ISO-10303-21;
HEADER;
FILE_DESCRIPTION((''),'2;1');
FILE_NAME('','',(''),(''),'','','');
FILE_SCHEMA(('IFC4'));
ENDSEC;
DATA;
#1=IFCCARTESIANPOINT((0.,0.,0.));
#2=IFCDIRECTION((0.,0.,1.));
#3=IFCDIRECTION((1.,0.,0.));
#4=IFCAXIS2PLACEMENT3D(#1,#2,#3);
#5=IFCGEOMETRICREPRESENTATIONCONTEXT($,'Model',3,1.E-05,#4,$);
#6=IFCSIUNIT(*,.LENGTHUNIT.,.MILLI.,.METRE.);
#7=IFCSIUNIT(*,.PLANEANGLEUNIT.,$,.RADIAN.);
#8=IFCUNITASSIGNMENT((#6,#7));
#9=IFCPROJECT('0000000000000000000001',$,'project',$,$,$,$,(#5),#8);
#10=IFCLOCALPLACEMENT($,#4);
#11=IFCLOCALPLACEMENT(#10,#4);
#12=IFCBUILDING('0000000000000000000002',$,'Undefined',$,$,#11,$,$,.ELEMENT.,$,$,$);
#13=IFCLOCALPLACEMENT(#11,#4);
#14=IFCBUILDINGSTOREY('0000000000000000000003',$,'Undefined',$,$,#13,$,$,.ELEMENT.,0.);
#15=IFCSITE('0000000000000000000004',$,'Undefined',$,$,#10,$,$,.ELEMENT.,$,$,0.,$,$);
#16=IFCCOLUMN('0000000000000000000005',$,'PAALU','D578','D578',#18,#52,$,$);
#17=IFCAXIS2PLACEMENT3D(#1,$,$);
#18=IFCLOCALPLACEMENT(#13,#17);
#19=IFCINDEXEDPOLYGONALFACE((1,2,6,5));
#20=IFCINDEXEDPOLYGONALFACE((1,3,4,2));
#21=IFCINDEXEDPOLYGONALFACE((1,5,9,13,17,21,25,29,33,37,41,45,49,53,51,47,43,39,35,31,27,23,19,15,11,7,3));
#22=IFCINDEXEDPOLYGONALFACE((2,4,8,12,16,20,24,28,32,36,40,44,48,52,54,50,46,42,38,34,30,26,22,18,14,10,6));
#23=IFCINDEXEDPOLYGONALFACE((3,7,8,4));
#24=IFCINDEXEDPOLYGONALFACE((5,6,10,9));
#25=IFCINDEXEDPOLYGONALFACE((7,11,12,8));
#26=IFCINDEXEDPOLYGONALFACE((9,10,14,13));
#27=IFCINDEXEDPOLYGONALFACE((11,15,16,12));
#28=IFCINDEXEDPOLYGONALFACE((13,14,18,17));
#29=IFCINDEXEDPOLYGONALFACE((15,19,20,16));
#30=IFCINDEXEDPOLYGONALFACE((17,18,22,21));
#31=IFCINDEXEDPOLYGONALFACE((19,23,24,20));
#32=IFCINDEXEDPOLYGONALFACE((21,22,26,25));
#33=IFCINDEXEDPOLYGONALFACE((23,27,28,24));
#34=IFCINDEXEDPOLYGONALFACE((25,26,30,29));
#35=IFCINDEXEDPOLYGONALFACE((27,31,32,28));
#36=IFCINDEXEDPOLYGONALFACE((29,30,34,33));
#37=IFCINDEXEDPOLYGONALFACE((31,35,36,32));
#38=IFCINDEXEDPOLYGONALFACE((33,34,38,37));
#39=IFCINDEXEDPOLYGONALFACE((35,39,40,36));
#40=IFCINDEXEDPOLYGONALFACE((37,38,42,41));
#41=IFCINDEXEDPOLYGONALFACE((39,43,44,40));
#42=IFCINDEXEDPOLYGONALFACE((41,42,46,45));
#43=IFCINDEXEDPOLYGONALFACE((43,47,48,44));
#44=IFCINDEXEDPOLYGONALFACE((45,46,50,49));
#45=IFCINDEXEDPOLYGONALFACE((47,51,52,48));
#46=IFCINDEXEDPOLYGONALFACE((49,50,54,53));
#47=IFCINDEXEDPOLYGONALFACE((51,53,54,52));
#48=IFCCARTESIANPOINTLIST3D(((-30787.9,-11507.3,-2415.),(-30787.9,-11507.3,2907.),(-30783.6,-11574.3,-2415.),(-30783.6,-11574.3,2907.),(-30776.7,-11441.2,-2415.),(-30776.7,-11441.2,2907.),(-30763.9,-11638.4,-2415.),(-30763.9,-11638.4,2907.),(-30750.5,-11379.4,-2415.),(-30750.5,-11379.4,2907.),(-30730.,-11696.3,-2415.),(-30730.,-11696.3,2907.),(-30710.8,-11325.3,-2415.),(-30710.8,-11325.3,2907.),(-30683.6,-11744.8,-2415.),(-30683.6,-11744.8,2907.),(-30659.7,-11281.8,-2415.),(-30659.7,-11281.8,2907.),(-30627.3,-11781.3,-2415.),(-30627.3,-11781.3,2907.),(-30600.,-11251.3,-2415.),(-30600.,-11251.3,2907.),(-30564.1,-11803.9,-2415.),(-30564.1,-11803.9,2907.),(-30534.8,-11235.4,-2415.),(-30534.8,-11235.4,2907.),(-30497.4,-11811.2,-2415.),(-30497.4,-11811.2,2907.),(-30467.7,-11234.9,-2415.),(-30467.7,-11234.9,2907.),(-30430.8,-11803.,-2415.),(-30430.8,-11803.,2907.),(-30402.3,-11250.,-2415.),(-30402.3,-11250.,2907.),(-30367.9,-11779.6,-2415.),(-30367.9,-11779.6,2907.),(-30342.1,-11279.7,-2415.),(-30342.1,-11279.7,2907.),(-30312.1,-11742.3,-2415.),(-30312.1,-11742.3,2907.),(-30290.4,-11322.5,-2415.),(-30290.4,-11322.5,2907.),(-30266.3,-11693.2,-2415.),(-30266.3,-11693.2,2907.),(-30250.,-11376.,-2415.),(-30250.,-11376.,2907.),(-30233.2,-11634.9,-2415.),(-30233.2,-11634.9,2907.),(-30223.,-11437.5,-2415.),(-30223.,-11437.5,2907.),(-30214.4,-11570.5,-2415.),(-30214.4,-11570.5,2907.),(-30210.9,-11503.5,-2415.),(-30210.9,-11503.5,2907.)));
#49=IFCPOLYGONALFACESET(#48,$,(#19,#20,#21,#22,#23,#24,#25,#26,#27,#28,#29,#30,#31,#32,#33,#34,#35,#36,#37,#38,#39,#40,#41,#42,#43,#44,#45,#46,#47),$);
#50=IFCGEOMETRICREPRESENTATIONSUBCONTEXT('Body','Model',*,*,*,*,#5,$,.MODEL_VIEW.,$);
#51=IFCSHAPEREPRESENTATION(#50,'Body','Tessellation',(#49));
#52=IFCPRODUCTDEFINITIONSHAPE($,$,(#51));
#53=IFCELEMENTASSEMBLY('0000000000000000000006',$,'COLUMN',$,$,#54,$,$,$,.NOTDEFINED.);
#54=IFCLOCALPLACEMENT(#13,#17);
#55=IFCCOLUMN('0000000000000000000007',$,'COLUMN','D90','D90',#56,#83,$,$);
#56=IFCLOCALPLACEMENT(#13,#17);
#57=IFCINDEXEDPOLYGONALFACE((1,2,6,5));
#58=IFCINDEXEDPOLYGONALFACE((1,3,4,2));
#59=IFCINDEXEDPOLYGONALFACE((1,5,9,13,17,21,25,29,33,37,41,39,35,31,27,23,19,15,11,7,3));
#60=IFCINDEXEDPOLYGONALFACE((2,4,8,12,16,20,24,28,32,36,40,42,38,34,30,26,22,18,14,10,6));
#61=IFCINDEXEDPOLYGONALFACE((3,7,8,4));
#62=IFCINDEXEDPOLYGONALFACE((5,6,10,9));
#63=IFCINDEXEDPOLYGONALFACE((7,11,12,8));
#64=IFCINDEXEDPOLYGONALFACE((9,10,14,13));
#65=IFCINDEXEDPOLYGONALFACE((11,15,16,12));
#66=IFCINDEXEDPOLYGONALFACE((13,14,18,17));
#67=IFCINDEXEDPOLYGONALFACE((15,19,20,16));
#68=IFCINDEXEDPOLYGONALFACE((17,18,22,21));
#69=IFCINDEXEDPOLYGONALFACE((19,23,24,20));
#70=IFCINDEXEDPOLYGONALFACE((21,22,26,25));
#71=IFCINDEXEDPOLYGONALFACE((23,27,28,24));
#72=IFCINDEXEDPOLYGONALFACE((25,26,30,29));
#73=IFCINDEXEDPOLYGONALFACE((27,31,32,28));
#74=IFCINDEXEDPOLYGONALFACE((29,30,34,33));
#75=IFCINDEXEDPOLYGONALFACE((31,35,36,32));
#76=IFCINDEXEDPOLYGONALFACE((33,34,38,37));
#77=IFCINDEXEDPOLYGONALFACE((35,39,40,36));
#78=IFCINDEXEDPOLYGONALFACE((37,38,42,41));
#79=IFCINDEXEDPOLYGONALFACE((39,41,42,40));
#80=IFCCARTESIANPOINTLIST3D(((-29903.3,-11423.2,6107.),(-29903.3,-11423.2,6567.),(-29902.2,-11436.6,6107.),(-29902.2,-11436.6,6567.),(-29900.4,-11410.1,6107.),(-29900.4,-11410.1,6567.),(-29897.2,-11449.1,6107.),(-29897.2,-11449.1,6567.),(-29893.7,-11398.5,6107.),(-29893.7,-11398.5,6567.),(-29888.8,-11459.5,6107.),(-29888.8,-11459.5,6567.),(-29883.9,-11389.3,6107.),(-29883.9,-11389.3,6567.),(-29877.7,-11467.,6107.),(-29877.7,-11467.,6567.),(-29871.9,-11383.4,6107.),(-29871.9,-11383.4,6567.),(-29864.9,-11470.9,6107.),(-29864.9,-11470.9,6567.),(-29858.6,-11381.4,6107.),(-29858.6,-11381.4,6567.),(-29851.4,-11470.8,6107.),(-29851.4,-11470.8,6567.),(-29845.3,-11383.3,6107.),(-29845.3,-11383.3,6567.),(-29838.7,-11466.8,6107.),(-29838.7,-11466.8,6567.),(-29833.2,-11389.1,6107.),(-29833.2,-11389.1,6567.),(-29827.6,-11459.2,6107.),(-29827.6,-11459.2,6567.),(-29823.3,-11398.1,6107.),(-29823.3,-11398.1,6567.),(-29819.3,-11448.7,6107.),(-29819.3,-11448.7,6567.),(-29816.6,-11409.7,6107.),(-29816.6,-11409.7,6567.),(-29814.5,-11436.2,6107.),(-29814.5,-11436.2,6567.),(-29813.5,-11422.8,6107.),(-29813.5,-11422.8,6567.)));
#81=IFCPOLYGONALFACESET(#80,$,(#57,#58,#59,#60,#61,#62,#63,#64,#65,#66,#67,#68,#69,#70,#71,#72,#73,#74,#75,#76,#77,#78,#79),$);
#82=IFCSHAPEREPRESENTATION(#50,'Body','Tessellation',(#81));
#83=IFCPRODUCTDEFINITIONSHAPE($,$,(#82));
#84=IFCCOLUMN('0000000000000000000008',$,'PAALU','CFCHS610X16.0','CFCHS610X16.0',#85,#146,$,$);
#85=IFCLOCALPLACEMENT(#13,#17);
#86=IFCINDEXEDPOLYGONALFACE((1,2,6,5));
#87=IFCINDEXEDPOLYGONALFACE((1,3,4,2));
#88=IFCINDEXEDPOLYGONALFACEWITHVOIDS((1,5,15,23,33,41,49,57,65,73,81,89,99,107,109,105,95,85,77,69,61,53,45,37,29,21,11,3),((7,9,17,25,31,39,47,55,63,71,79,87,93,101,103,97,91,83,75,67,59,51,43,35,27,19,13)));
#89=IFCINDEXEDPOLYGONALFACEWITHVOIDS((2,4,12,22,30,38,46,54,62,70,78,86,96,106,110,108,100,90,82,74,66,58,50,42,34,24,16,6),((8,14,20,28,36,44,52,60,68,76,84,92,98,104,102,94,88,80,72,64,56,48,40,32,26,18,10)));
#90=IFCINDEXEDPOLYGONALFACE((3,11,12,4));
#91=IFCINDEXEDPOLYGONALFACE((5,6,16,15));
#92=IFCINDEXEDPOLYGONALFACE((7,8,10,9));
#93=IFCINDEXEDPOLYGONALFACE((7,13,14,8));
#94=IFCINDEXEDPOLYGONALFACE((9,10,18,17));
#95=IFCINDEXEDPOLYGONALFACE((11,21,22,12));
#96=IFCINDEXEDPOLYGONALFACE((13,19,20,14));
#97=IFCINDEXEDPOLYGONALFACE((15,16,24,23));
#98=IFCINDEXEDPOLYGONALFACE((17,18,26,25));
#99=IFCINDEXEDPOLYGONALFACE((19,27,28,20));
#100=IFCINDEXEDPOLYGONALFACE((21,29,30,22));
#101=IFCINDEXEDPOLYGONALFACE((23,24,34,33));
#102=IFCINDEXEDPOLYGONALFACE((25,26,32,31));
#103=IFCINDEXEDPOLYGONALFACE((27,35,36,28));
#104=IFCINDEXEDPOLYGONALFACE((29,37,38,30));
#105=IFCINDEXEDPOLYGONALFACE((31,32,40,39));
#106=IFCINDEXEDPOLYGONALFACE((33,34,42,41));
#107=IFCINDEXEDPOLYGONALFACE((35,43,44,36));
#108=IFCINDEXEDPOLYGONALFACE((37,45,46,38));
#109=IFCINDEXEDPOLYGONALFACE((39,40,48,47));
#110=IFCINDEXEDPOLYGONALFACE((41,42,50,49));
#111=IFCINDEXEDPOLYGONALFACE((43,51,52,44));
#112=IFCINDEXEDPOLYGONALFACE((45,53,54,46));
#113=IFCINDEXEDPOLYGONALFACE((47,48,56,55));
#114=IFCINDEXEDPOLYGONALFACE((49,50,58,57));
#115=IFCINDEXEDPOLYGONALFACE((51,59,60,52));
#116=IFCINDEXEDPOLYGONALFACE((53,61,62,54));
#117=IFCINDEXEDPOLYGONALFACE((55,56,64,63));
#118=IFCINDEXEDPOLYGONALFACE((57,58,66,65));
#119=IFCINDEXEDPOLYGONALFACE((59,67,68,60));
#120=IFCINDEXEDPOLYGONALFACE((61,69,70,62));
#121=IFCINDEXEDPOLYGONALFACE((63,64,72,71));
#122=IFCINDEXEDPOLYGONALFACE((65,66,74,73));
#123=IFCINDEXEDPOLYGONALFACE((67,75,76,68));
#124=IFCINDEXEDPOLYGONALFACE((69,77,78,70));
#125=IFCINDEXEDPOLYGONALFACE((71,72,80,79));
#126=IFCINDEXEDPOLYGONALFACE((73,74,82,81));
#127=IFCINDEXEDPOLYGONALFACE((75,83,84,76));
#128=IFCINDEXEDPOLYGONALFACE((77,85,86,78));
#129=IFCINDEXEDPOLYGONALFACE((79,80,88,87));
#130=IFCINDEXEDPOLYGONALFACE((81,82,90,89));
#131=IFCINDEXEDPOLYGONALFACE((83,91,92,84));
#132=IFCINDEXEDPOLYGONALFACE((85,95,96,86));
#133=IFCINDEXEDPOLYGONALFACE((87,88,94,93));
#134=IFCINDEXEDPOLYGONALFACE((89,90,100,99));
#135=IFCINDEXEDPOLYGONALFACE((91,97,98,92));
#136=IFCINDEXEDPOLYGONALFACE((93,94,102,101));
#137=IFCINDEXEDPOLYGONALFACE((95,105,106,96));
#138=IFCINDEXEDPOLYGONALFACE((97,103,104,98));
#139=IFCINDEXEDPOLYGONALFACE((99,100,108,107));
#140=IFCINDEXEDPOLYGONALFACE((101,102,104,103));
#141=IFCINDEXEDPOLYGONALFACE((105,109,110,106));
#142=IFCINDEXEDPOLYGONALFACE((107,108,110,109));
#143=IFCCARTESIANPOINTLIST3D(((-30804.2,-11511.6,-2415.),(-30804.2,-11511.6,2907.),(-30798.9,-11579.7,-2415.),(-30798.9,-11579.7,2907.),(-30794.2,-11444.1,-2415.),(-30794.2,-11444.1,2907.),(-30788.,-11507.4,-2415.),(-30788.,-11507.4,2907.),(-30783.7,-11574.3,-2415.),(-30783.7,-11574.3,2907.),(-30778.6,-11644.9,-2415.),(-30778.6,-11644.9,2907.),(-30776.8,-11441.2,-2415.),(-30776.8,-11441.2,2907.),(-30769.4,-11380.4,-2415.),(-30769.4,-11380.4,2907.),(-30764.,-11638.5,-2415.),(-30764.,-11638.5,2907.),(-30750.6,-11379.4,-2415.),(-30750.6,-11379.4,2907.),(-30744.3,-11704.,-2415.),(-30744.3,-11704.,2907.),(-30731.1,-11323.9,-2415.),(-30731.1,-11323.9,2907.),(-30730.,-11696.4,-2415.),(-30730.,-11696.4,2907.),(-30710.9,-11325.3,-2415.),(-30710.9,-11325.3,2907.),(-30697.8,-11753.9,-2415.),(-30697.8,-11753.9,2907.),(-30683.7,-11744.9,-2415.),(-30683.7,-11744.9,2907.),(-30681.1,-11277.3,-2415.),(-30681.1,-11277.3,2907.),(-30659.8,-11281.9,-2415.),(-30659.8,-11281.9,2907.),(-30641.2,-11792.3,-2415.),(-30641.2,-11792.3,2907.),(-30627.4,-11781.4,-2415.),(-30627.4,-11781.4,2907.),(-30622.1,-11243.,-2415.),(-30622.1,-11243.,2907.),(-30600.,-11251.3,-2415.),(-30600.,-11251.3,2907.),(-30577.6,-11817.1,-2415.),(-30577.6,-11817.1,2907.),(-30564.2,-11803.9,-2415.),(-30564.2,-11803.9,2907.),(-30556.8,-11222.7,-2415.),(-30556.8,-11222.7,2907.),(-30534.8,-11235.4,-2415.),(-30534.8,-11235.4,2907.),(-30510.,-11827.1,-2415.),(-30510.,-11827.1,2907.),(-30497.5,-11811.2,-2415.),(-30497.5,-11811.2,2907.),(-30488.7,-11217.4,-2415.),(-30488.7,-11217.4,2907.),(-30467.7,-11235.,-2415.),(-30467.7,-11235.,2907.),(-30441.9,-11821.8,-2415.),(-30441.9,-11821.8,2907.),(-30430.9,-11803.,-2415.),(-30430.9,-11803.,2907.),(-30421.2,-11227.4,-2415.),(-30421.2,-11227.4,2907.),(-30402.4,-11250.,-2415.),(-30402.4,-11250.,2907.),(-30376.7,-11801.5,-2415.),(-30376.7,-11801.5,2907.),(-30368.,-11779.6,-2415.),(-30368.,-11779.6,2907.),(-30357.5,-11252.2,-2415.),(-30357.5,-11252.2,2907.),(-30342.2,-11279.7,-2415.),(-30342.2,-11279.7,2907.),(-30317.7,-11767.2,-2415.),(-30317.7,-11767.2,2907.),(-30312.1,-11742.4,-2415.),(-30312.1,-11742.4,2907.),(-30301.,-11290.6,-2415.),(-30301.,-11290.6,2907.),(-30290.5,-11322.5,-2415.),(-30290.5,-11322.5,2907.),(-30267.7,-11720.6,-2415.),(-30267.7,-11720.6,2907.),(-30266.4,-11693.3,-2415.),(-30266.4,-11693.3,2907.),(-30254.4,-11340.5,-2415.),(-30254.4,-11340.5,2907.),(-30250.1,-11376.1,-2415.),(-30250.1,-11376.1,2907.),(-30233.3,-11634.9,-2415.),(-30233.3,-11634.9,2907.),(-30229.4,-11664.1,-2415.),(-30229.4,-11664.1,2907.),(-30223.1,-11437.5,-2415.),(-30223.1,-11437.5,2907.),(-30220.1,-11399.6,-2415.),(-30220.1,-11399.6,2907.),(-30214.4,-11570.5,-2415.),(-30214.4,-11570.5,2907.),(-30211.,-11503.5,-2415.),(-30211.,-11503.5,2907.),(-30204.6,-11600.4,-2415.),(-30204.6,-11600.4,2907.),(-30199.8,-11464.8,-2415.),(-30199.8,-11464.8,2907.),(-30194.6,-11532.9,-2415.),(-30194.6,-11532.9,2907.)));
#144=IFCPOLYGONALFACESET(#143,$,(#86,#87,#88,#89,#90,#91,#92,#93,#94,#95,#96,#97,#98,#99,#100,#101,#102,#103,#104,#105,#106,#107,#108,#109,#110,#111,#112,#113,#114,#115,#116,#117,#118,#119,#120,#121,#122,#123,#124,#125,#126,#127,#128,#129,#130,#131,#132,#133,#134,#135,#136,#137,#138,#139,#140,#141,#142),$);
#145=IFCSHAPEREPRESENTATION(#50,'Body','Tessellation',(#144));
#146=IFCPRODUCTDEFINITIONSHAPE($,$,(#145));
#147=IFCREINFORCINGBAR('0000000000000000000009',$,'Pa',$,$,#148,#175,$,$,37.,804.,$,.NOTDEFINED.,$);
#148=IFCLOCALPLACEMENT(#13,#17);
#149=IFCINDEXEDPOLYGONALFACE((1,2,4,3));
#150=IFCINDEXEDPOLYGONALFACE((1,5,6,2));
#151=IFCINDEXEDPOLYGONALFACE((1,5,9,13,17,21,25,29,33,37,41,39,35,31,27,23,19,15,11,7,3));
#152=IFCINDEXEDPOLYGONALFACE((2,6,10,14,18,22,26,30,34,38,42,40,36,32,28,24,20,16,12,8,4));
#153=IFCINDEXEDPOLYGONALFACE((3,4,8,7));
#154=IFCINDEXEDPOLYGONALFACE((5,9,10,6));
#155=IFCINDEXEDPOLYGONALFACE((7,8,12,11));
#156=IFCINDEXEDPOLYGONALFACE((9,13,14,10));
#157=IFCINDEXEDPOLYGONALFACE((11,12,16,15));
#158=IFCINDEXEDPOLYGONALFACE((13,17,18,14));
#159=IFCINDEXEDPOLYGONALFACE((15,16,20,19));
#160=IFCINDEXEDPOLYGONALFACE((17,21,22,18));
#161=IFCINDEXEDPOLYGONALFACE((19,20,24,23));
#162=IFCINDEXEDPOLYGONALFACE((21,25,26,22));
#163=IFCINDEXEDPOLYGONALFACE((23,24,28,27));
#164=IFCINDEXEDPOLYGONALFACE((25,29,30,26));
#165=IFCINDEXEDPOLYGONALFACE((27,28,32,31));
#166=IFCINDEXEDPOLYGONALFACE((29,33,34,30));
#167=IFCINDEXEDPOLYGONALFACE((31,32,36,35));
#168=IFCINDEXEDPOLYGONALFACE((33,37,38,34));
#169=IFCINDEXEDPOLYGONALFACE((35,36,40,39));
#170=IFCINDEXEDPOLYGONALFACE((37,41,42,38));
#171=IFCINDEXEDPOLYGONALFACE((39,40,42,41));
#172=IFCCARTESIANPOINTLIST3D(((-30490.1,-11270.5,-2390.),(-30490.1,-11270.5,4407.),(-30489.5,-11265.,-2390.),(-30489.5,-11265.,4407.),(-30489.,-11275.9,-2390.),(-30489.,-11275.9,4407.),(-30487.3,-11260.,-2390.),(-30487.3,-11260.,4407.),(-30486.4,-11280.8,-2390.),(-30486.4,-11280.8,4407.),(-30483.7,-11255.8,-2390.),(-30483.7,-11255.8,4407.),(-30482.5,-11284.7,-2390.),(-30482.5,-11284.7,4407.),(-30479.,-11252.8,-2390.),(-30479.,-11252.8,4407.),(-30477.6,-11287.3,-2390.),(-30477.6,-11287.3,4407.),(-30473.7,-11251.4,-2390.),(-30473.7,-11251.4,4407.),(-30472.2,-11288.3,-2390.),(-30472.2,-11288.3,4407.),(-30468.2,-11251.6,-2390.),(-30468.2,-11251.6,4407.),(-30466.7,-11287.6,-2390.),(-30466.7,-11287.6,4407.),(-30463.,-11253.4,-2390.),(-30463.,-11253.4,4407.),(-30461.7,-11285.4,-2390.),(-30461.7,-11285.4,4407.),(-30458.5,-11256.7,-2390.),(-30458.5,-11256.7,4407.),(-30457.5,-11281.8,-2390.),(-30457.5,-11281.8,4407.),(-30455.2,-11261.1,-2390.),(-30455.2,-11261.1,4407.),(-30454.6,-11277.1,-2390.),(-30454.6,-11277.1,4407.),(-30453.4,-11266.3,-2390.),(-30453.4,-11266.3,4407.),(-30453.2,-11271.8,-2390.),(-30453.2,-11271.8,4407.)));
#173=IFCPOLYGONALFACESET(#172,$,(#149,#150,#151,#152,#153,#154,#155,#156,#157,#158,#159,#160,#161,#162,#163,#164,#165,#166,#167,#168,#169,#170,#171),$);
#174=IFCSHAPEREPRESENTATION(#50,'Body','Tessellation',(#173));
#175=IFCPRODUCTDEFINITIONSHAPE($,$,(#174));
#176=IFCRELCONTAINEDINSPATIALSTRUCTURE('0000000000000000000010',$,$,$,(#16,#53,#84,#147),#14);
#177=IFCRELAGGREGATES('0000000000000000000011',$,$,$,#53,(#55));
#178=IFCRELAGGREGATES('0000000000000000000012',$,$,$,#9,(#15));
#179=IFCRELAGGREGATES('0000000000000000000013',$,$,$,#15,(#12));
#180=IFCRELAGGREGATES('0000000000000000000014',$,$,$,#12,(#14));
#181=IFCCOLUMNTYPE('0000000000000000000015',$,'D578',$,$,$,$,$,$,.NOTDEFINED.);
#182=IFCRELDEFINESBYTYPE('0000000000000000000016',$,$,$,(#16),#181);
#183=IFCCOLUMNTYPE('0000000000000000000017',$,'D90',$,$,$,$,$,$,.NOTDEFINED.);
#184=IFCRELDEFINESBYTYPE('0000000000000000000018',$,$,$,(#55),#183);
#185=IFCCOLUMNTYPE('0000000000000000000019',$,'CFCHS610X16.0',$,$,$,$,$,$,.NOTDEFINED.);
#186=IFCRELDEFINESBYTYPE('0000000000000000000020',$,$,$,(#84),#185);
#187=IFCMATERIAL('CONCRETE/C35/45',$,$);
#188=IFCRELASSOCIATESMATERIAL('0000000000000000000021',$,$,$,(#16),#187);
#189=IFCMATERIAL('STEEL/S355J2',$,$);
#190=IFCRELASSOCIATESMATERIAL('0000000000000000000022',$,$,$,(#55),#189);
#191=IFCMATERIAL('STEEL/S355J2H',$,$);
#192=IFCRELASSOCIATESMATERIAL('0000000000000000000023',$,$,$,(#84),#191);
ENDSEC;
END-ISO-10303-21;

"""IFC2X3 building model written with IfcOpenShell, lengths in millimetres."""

from ifc_helpers import new_model, entity, si_unit, frame, origin_with_axes, origin_2d_with_axis, place, context, subcontext, project, spatial, circle, hollow_circle, extrude, source, transform, mapped, material, type_object, element, aggregate, save


model = new_model("IFC2X3")

# Units and contexts
model_context = context("Model", 3, precision=1e-05, world=origin_with_axes())
body_context = subcontext(model_context, "Body", "Model", "MODEL_VIEW")
ifc_project = project(units=[si_unit("LENGTHUNIT", "METRE", prefix="MILLI"), si_unit("PLANEANGLEUNIT", "RADIAN")], contexts=[model_context])

# Site, building, storey
site_placement = place(None, origin_with_axes())
site = spatial("IfcSite", under=ifc_project, at=site_placement, Name="Undefined", CompositionType="ELEMENT", RefElevation=0.0)
building_placement = place(site_placement, origin_with_axes())
building = spatial("IfcBuilding", under=site, at=building_placement, Name="Undefined", CompositionType="ELEMENT")
storey_placement = place(building_placement, origin_with_axes())
storey = spatial("IfcBuildingStorey", under=building, at=storey_placement, Name="Undefined", CompositionType="ELEMENT", Elevation=0.0)

# Column
ifc_material_1 = material(Name="CONCRETE/C35/45")
column_type_1 = type_object("IfcColumnType", Name="D578", PredefinedType="NOTDEFINED")
column_1_placement = place(storey_placement, frame((-30499.3, -11522.2, -2415.0), z_axis=(0.0, 0.0, 1.0), x_axis=(1.0, 0.0, 0.0)))
element("IfcColumn", 1, at=column_1_placement, inside=storey, type_object=column_type_1, material=ifc_material_1, Name="PAALU", Description="D578", ObjectType="D578", context=body_context, shape_type="SweptSolid", body=[
    extrude(circle(Radius=289.0, at=origin_2d_with_axis()), frame((0.0, 0.0, 5322.0), z_axis=(0.0, 0.0, -1.0), x_axis=(-0.915553, -0.402197, 0.0)), (0.0, 0.0, 1.0), 5322.0),
])

# Element assembly, column
assembly_placement = place(storey_placement, frame((-29858.4, -11426.4, 6107.0), z_axis=(-0.736467, 0.676473, 0.0), x_axis=(0.0, 0.0, 1.0)))
assembly = element("IfcElementAssembly", 2, at=assembly_placement, inside=storey, Name="COLUMN", PredefinedType="NOTDEFINED")
ifc_material_2 = material(Name="STEEL/S355J2")
column_type_2 = type_object("IfcColumnType", Name="D90", PredefinedType="NOTDEFINED")
column_2_placement = place(storey_placement, frame((-29858.4, -11426.4, 6107.0), z_axis=(0.0, 0.0, 1.0), x_axis=(1.0, 0.0, 0.0)))
column_2 = element("IfcColumn", 3, at=column_2_placement, type_object=column_type_2, material=ifc_material_2, Name="COLUMN", Description="D90", ObjectType="D90", context=body_context, shape_type="SweptSolid", body=[
    extrude(circle(Radius=45.0, at=origin_2d_with_axis()), frame((0.0, 0.0, 460.0), z_axis=(0.0, 0.0, -1.0), x_axis=(-0.676473, -0.736467, 0.0)), (0.0, 0.0, 1.0), 460.0),
])
aggregate(assembly, [column_2])

# Column
ifc_material_3 = material(Name="STEEL/S355J2H")
column_type_3 = type_object("IfcColumnType", Name="CFCHS610X16.0", PredefinedType="NOTDEFINED")
column_3_placement = place(storey_placement, frame((-30499.4, -11522.2, -2415.0), z_axis=(0.0, 0.0, 1.0), x_axis=(1.0, 0.0, 0.0)))
element("IfcColumn", 4, at=column_3_placement, inside=storey, type_object=column_type_3, material=ifc_material_3, Name="PAALU", Description="CFCHS610X16.0", ObjectType="CFCHS610X16.0", context=body_context, shape_type="SweptSolid", body=[
    extrude(hollow_circle(Radius=305.0, WallThickness=16.0, at=origin_2d_with_axis()), frame((0.0, 0.0, 5322.0), z_axis=(0.0, 0.0, -1.0), x_axis=(-0.915553, -0.402197, 0.0)), (0.0, 0.0, 1.0), 5322.0),
])

# Reinforcing bar
shared_shape_1 = source(origin_with_axes(), body_context, "Body", "AdvancedSweptSolid", [
    entity("IfcSweptDiskSolid", entity("IfcTrimmedCurve", entity("IfcLine", entity("IfcCartesianPoint", [0.0, 0.0, 0.0]), entity("IfcVector", entity("IfcDirection", [1.0, 0.0, 0.0]), 1.0)), [entity("IfcParameterValue", 0.0)], [entity("IfcParameterValue", 6797.0)], True, "PARAMETER"), 18.5, None, 0.0, 6797.0),
])
reinforcing_bar_1_placement = place(storey_placement, frame((-30471.6, -11269.8, -2390.0), z_axis=(0.993991, -0.109464, 0.0), x_axis=(0.0, 0.0, 1.0)))
element("IfcReinforcingBar", 5, at=reinforcing_bar_1_placement, inside=storey, Name="Pa", BarRole="NOTDEFINED", CrossSectionArea=804.0, NominalDiameter=37.0, context=body_context, shape_type="MappedRepresentation", body=[
    mapped(shared_shape_1, transform((0.0, 0.0, 0.0))),
])

save(model, "model.ifc")
